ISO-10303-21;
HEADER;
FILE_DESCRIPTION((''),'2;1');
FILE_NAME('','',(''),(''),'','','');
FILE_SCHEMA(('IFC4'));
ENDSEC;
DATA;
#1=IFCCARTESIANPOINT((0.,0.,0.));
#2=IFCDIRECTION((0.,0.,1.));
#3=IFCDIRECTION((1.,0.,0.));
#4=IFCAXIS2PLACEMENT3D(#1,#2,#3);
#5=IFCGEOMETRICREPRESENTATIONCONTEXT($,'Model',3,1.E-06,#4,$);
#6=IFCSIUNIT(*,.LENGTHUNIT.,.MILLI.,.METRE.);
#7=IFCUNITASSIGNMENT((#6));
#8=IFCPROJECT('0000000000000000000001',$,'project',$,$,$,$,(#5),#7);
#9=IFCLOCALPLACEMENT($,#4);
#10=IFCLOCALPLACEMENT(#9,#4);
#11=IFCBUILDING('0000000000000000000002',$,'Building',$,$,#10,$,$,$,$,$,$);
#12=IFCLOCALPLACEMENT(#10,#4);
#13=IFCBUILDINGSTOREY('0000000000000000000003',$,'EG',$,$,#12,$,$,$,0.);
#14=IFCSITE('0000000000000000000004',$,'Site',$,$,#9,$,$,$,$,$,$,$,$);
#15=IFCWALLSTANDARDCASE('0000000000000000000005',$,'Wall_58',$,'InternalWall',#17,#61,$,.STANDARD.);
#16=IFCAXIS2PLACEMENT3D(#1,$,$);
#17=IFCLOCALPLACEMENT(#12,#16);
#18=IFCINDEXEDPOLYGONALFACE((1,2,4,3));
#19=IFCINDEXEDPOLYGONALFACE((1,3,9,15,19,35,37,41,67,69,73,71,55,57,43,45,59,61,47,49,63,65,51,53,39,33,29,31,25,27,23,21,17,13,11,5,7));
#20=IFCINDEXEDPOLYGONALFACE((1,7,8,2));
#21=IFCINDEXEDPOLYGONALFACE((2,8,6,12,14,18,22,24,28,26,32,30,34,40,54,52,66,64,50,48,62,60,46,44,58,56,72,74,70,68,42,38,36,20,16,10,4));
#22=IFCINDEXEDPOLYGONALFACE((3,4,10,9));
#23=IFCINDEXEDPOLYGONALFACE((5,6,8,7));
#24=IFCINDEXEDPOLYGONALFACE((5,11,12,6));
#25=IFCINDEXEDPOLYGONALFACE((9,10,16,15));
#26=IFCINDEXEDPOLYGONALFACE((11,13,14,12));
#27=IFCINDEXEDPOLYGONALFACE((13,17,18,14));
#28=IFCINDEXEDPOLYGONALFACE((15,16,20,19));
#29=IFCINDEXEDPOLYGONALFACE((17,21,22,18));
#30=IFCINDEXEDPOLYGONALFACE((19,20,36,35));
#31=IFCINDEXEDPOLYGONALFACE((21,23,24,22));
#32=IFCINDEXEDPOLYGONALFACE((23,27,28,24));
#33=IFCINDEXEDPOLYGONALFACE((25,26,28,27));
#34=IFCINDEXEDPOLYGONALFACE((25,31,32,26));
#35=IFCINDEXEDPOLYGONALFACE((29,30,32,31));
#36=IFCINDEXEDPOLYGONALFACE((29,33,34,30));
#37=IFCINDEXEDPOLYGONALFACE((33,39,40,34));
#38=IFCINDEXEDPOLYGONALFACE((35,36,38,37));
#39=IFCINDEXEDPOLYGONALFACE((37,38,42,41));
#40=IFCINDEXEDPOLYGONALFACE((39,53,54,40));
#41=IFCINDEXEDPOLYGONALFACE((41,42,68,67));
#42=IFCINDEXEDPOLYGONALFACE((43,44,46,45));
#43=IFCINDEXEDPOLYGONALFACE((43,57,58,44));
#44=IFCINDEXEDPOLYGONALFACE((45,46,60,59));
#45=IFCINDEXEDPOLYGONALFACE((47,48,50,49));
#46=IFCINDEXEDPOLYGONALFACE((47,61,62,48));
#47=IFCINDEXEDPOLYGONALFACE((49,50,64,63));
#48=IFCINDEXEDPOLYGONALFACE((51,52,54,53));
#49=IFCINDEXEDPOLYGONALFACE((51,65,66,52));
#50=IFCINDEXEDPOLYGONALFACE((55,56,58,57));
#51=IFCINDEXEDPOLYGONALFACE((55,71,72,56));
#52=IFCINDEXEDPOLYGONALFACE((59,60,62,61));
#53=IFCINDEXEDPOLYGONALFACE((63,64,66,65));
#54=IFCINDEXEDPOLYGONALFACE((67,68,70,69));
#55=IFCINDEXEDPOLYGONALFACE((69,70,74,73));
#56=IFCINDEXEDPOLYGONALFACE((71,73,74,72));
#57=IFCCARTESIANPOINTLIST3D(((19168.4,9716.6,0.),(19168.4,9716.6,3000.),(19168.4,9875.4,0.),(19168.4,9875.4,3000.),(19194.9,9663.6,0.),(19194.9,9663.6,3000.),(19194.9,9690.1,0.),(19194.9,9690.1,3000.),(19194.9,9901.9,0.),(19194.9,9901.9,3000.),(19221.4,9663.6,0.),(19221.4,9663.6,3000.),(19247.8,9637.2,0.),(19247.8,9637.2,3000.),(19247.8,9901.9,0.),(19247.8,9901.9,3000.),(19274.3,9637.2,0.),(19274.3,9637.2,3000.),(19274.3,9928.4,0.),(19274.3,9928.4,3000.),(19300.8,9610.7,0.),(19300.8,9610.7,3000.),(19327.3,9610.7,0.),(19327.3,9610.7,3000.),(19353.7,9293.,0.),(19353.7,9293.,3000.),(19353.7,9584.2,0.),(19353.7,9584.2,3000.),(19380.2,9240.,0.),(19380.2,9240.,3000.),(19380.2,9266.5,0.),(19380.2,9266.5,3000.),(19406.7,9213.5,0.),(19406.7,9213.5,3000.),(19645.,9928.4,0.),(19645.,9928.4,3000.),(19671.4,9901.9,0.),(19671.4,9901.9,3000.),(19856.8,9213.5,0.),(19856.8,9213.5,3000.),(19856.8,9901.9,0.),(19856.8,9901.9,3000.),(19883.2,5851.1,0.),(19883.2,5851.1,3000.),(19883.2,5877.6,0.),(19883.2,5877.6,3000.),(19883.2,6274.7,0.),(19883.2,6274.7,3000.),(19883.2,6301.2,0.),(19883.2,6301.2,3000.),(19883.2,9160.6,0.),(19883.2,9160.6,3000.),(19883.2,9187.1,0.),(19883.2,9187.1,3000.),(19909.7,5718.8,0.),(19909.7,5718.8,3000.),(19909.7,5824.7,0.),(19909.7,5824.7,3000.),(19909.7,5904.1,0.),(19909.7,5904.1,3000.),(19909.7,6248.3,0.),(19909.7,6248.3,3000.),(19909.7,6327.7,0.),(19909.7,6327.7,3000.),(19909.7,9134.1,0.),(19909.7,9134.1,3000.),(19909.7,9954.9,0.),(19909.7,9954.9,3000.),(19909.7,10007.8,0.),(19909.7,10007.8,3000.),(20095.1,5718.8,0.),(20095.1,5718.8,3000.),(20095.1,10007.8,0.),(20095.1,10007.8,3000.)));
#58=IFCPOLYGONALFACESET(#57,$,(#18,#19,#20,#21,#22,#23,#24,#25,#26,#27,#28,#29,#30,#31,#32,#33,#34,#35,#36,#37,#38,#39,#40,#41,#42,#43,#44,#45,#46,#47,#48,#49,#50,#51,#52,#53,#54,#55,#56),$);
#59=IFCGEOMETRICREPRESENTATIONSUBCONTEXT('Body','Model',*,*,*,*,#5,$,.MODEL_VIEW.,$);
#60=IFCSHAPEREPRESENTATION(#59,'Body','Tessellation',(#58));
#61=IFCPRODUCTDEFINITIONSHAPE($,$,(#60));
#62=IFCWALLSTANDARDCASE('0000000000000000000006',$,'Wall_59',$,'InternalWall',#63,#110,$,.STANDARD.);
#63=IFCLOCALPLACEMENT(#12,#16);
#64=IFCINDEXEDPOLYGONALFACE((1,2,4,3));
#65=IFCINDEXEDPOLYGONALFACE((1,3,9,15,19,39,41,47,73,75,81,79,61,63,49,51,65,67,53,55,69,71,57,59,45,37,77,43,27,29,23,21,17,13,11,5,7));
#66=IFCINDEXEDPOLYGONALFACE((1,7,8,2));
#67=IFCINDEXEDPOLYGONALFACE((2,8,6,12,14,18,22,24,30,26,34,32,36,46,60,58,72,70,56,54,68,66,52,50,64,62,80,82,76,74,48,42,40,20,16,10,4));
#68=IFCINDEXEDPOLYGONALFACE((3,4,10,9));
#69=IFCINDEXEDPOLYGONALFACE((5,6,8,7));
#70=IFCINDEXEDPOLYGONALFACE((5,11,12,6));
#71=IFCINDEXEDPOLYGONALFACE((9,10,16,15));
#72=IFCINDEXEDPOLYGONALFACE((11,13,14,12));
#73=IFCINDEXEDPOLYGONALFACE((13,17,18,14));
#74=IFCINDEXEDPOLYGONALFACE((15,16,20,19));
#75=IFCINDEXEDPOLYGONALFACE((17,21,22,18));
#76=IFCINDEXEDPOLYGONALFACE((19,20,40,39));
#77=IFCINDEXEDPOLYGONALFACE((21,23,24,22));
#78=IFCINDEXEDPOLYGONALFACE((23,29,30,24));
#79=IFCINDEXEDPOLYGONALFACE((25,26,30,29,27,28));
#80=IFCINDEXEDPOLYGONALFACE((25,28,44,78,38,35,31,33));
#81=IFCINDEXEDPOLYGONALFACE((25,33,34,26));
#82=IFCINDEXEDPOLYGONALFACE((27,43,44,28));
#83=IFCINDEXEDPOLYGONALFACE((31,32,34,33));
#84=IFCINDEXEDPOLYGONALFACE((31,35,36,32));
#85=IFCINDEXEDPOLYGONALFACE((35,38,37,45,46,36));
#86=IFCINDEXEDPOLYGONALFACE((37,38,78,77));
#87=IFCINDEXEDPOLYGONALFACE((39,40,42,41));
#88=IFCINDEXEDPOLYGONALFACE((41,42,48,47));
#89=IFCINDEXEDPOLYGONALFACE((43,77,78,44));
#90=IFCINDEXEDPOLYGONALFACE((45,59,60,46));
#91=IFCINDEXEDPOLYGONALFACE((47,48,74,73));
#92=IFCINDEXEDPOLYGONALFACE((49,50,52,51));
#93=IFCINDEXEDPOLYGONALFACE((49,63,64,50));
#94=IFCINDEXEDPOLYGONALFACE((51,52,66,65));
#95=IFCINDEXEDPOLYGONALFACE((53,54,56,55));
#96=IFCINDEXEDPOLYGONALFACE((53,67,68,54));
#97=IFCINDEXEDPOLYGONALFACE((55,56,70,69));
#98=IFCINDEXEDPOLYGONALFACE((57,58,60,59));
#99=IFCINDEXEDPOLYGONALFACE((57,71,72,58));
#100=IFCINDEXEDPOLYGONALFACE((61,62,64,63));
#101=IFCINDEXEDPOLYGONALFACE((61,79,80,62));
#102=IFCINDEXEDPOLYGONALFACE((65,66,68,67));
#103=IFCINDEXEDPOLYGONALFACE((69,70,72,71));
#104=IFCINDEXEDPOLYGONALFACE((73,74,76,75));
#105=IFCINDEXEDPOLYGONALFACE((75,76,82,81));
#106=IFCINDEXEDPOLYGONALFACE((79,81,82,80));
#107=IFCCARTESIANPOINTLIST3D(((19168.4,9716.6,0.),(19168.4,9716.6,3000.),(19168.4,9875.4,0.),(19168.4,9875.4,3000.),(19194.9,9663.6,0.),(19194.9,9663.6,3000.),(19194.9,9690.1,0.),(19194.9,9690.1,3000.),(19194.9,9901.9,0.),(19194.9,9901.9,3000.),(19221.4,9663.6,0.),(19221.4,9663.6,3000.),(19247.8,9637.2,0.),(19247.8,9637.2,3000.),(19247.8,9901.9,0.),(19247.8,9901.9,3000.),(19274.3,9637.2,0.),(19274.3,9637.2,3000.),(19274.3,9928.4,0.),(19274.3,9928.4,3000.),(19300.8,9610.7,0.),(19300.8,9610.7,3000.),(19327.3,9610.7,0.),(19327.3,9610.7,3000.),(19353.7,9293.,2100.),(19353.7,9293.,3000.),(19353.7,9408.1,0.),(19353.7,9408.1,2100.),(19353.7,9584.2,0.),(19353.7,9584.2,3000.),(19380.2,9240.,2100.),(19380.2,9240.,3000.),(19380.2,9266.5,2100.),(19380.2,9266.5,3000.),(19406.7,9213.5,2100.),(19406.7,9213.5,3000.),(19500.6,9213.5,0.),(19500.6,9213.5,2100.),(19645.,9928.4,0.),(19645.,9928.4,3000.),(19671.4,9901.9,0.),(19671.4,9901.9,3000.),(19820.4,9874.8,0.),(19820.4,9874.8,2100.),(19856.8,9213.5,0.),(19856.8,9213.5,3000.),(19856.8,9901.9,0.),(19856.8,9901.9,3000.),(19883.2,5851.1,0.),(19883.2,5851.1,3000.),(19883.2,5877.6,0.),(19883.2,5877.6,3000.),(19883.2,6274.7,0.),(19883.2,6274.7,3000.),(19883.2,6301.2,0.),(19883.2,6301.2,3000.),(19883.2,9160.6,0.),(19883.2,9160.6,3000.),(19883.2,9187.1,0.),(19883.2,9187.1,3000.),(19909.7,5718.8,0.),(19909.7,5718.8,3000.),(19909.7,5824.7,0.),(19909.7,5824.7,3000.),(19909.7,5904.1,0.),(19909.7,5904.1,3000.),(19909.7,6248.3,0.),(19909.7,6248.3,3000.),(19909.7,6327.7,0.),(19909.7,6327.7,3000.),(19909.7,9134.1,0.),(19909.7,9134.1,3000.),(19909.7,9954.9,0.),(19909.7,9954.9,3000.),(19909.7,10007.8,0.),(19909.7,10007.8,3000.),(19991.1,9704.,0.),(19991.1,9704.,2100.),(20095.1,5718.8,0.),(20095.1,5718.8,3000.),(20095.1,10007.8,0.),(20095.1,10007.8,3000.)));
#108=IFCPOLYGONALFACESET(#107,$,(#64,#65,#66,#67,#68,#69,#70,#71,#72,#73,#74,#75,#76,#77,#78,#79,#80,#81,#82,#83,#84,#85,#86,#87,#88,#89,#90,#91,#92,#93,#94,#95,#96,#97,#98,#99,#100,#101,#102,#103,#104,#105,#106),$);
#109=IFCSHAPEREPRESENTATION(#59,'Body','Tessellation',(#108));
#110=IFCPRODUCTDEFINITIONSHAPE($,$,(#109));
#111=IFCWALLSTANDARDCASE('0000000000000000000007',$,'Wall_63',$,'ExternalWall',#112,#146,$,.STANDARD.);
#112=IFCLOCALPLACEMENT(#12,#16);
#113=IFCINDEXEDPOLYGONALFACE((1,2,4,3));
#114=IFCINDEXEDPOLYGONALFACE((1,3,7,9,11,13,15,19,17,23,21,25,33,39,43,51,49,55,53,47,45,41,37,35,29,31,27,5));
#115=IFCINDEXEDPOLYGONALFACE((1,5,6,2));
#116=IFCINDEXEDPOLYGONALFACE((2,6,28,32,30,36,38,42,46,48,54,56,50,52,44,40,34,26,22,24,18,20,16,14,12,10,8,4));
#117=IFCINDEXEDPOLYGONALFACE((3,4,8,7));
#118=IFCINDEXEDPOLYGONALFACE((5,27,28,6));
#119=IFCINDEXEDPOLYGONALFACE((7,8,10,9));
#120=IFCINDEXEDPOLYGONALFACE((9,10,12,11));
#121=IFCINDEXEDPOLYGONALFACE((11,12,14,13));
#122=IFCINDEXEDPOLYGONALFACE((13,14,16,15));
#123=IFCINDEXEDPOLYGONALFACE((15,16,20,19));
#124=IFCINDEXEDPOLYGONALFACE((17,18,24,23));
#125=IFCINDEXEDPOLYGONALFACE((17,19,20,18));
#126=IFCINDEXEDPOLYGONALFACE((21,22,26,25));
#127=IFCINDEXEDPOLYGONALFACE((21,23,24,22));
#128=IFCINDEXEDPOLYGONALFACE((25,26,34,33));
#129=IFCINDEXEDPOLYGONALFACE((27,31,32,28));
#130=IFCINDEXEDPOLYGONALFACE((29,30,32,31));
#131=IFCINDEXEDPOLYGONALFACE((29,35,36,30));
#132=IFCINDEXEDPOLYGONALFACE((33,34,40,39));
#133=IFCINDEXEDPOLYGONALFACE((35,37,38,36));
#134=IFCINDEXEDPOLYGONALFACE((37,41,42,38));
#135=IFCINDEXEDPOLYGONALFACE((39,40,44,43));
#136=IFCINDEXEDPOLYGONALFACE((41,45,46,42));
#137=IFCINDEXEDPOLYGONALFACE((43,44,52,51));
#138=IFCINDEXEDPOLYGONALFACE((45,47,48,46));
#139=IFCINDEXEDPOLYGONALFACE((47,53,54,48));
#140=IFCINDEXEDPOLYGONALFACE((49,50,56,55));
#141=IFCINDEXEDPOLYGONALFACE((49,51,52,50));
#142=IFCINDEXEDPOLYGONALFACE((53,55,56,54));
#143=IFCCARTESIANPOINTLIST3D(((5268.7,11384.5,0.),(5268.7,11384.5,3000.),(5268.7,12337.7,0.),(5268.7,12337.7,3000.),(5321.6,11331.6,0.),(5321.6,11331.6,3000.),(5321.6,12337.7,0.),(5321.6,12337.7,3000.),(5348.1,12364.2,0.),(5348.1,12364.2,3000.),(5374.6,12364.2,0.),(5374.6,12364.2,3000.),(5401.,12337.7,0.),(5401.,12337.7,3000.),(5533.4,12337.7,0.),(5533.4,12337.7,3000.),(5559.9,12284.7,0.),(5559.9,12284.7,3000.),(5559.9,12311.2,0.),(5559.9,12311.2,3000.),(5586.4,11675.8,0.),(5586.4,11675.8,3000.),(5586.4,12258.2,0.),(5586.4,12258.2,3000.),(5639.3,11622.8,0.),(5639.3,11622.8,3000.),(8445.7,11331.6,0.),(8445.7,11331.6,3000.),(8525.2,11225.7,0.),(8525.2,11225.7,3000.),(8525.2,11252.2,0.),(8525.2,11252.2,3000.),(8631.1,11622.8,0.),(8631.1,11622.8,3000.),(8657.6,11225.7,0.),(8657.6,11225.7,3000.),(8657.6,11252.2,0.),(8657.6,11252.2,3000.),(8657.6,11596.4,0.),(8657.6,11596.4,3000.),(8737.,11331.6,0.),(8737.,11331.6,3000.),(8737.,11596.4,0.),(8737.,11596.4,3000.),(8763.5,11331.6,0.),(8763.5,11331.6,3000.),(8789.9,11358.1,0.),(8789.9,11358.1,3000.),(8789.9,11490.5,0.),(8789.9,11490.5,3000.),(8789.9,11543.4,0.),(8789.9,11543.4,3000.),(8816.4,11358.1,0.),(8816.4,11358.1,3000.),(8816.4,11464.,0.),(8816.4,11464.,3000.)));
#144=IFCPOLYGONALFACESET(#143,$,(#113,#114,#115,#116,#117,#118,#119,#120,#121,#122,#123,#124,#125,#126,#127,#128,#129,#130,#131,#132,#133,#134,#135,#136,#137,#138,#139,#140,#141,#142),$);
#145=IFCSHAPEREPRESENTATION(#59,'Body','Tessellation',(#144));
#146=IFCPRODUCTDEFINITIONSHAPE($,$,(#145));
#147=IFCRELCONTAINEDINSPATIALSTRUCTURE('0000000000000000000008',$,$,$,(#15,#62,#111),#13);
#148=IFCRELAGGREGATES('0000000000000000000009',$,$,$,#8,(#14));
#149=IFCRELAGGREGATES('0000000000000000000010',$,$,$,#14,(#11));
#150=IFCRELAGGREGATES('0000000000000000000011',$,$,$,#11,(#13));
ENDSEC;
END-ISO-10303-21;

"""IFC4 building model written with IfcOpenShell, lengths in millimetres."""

from ifc_helpers import new_model, si_unit, frame, origin_with_axes, place, context, subcontext, project, spatial, polyline, rectangle, outline, extrude, element, save


model = new_model("IFC4")

# Units and contexts
model_context = context("Model", 3, precision=1e-06, world=origin_with_axes())
body_context = subcontext(model_context, "Body", "Model", "MODEL_VIEW")
ifc_project = project(units=[si_unit("LENGTHUNIT", "METRE", prefix="MILLI")], contexts=[model_context])

# Site, building, storey
site_placement = place(None, origin_with_axes())
site = spatial("IfcSite", under=ifc_project, at=site_placement, Name="Site")
building_placement = place(site_placement, origin_with_axes())
building = spatial("IfcBuilding", under=site, at=building_placement, Name="Building")
storey_placement = place(building_placement, origin_with_axes())
storey = spatial("IfcBuildingStorey", under=building, at=storey_placement, Name="EG", Elevation=0.0)

# Wall
wall_1_placement = place(storey_placement, origin_with_axes())
element("IfcWallStandardCase", 1, at=wall_1_placement, inside=storey, Name="Wall_58", ObjectType="InternalWall", PredefinedType="STANDARD", context=body_context, shape_type="SweptSolid", body=[
    extrude(outline(polyline([(19909.7, 5718.8, 0.0), (19909.7, 5824.7, 0.0), (19883.2, 5851.1, 0.0), (19883.2, 5877.6, 0.0), (19909.7, 5904.1, 0.0), (19909.7, 6248.3, 0.0), (19883.2, 6274.7, 0.0), (19883.2, 6301.2, 0.0), (19909.7, 6327.7, 0.0), (19909.7, 9134.1, 0.0), (19883.2, 9160.6, 0.0), (19883.2, 9187.1, 0.0), (19856.8, 9213.5, 0.0), (19406.7, 9213.5, 0.0), (19380.2, 9240.0, 0.0), (19380.2, 9266.5, 0.0), (19353.7, 9293.0, 0.0), (19353.7, 9584.2, 0.0), (19327.3, 9610.7, 0.0), (19300.8, 9610.7, 0.0), (19274.3, 9637.2, 0.0), (19247.8, 9637.2, 0.0), (19221.4, 9663.6, 0.0), (19194.9, 9663.6, 0.0), (19194.9, 9690.1, 0.0), (19168.4, 9716.6, 0.0), (19168.4, 9875.4, 0.0), (19194.9, 9901.9, 0.0), (19247.8, 9901.9, 0.0), (19274.3, 9928.4, 0.0), (19645.0, 9928.4, 0.0), (19671.4, 9901.9, 0.0), (19856.8, 9901.9, 0.0), (19909.7, 9954.9, 0.0), (19909.7, 10007.8, 0.0), (20095.1, 10007.8, 0.0), (20095.1, 5718.8, 0.0), (19909.7, 5718.8, 0.0)])), origin_with_axes(), (0.0, 0.0, 1.0), 3000.0),
])

# Wall, opening
wall_2_placement = place(storey_placement, origin_with_axes())
wall_2 = element("IfcWallStandardCase", 2, at=wall_2_placement, inside=storey, Name="Wall_59", ObjectType="InternalWall", PredefinedType="STANDARD", context=body_context, shape_type="SweptSolid", body=[
    extrude(outline(polyline([(19909.7, 5718.8, 0.0), (19909.7, 5824.7, 0.0), (19883.2, 5851.1, 0.0), (19883.2, 5877.6, 0.0), (19909.7, 5904.1, 0.0), (19909.7, 6248.3, 0.0), (19883.2, 6274.7, 0.0), (19883.2, 6301.2, 0.0), (19909.7, 6327.7, 0.0), (19909.7, 9134.1, 0.0), (19883.2, 9160.6, 0.0), (19883.2, 9187.1, 0.0), (19856.8, 9213.5, 0.0), (19406.7, 9213.5, 0.0), (19380.2, 9240.0, 0.0), (19380.2, 9266.5, 0.0), (19353.7, 9293.0, 0.0), (19353.7, 9584.2, 0.0), (19327.3, 9610.7, 0.0), (19300.8, 9610.7, 0.0), (19274.3, 9637.2, 0.0), (19247.8, 9637.2, 0.0), (19221.4, 9663.6, 0.0), (19194.9, 9663.6, 0.0), (19194.9, 9690.1, 0.0), (19168.4, 9716.6, 0.0), (19168.4, 9875.4, 0.0), (19194.9, 9901.9, 0.0), (19247.8, 9901.9, 0.0), (19274.3, 9928.4, 0.0), (19645.0, 9928.4, 0.0), (19671.4, 9901.9, 0.0), (19856.8, 9901.9, 0.0), (19909.7, 9954.9, 0.0), (19909.7, 10007.8, 0.0), (20095.1, 10007.8, 0.0), (20095.1, 5718.8, 0.0), (19909.7, 5718.8, 0.0)])), origin_with_axes(), (0.0, 0.0, 1.0), 3000.0),
])
opening_1_placement = place(wall_2_placement, origin_with_axes())
element("IfcOpeningElement", 3, at=opening_1_placement, inside=storey, cuts=wall_2, context=body_context, shape_type="SweptSolid", body=[
    extrude(rectangle(XDim=1048.4, YDim=241.4), frame((19535.1, 9418.8, 0.0), z_axis=(0.0, 0.0, 1.0), x_axis=(-0.707107, -0.707107, 0.0)), (0.0, 0.0, 1.0), 2100.0),
])

# Wall
wall_3_placement = place(storey_placement, origin_with_axes())
element("IfcWallStandardCase", 4, at=wall_3_placement, inside=storey, Name="Wall_63", ObjectType="ExternalWall", PredefinedType="STANDARD", context=body_context, shape_type="SweptSolid", body=[
    extrude(outline(polyline([(8525.2, 11225.7, 0.0), (8525.2, 11252.2, 0.0), (8445.7, 11331.6, 0.0), (5321.6, 11331.6, 0.0), (5268.7, 11384.5, 0.0), (5268.7, 12337.7, 0.0), (5321.6, 12337.7, 0.0), (5348.1, 12364.2, 0.0), (5374.6, 12364.2, 0.0), (5401.0, 12337.7, 0.0), (5533.4, 12337.7, 0.0), (5559.9, 12311.2, 0.0), (5559.9, 12284.7, 0.0), (5586.4, 12258.2, 0.0), (5586.4, 11675.8, 0.0), (5639.3, 11622.8, 0.0), (8631.1, 11622.8, 0.0), (8657.6, 11596.4, 0.0), (8737.0, 11596.4, 0.0), (8789.9, 11543.4, 0.0), (8789.9, 11490.5, 0.0), (8816.4, 11464.0, 0.0), (8816.4, 11358.1, 0.0), (8789.9, 11358.1, 0.0), (8763.5, 11331.6, 0.0), (8737.0, 11331.6, 0.0), (8657.6, 11252.2, 0.0), (8657.6, 11225.7, 0.0), (8525.2, 11225.7, 0.0)])), origin_with_axes(), (0.0, 0.0, 1.0), 3000.0),
])

save(model, "model.ifc")
